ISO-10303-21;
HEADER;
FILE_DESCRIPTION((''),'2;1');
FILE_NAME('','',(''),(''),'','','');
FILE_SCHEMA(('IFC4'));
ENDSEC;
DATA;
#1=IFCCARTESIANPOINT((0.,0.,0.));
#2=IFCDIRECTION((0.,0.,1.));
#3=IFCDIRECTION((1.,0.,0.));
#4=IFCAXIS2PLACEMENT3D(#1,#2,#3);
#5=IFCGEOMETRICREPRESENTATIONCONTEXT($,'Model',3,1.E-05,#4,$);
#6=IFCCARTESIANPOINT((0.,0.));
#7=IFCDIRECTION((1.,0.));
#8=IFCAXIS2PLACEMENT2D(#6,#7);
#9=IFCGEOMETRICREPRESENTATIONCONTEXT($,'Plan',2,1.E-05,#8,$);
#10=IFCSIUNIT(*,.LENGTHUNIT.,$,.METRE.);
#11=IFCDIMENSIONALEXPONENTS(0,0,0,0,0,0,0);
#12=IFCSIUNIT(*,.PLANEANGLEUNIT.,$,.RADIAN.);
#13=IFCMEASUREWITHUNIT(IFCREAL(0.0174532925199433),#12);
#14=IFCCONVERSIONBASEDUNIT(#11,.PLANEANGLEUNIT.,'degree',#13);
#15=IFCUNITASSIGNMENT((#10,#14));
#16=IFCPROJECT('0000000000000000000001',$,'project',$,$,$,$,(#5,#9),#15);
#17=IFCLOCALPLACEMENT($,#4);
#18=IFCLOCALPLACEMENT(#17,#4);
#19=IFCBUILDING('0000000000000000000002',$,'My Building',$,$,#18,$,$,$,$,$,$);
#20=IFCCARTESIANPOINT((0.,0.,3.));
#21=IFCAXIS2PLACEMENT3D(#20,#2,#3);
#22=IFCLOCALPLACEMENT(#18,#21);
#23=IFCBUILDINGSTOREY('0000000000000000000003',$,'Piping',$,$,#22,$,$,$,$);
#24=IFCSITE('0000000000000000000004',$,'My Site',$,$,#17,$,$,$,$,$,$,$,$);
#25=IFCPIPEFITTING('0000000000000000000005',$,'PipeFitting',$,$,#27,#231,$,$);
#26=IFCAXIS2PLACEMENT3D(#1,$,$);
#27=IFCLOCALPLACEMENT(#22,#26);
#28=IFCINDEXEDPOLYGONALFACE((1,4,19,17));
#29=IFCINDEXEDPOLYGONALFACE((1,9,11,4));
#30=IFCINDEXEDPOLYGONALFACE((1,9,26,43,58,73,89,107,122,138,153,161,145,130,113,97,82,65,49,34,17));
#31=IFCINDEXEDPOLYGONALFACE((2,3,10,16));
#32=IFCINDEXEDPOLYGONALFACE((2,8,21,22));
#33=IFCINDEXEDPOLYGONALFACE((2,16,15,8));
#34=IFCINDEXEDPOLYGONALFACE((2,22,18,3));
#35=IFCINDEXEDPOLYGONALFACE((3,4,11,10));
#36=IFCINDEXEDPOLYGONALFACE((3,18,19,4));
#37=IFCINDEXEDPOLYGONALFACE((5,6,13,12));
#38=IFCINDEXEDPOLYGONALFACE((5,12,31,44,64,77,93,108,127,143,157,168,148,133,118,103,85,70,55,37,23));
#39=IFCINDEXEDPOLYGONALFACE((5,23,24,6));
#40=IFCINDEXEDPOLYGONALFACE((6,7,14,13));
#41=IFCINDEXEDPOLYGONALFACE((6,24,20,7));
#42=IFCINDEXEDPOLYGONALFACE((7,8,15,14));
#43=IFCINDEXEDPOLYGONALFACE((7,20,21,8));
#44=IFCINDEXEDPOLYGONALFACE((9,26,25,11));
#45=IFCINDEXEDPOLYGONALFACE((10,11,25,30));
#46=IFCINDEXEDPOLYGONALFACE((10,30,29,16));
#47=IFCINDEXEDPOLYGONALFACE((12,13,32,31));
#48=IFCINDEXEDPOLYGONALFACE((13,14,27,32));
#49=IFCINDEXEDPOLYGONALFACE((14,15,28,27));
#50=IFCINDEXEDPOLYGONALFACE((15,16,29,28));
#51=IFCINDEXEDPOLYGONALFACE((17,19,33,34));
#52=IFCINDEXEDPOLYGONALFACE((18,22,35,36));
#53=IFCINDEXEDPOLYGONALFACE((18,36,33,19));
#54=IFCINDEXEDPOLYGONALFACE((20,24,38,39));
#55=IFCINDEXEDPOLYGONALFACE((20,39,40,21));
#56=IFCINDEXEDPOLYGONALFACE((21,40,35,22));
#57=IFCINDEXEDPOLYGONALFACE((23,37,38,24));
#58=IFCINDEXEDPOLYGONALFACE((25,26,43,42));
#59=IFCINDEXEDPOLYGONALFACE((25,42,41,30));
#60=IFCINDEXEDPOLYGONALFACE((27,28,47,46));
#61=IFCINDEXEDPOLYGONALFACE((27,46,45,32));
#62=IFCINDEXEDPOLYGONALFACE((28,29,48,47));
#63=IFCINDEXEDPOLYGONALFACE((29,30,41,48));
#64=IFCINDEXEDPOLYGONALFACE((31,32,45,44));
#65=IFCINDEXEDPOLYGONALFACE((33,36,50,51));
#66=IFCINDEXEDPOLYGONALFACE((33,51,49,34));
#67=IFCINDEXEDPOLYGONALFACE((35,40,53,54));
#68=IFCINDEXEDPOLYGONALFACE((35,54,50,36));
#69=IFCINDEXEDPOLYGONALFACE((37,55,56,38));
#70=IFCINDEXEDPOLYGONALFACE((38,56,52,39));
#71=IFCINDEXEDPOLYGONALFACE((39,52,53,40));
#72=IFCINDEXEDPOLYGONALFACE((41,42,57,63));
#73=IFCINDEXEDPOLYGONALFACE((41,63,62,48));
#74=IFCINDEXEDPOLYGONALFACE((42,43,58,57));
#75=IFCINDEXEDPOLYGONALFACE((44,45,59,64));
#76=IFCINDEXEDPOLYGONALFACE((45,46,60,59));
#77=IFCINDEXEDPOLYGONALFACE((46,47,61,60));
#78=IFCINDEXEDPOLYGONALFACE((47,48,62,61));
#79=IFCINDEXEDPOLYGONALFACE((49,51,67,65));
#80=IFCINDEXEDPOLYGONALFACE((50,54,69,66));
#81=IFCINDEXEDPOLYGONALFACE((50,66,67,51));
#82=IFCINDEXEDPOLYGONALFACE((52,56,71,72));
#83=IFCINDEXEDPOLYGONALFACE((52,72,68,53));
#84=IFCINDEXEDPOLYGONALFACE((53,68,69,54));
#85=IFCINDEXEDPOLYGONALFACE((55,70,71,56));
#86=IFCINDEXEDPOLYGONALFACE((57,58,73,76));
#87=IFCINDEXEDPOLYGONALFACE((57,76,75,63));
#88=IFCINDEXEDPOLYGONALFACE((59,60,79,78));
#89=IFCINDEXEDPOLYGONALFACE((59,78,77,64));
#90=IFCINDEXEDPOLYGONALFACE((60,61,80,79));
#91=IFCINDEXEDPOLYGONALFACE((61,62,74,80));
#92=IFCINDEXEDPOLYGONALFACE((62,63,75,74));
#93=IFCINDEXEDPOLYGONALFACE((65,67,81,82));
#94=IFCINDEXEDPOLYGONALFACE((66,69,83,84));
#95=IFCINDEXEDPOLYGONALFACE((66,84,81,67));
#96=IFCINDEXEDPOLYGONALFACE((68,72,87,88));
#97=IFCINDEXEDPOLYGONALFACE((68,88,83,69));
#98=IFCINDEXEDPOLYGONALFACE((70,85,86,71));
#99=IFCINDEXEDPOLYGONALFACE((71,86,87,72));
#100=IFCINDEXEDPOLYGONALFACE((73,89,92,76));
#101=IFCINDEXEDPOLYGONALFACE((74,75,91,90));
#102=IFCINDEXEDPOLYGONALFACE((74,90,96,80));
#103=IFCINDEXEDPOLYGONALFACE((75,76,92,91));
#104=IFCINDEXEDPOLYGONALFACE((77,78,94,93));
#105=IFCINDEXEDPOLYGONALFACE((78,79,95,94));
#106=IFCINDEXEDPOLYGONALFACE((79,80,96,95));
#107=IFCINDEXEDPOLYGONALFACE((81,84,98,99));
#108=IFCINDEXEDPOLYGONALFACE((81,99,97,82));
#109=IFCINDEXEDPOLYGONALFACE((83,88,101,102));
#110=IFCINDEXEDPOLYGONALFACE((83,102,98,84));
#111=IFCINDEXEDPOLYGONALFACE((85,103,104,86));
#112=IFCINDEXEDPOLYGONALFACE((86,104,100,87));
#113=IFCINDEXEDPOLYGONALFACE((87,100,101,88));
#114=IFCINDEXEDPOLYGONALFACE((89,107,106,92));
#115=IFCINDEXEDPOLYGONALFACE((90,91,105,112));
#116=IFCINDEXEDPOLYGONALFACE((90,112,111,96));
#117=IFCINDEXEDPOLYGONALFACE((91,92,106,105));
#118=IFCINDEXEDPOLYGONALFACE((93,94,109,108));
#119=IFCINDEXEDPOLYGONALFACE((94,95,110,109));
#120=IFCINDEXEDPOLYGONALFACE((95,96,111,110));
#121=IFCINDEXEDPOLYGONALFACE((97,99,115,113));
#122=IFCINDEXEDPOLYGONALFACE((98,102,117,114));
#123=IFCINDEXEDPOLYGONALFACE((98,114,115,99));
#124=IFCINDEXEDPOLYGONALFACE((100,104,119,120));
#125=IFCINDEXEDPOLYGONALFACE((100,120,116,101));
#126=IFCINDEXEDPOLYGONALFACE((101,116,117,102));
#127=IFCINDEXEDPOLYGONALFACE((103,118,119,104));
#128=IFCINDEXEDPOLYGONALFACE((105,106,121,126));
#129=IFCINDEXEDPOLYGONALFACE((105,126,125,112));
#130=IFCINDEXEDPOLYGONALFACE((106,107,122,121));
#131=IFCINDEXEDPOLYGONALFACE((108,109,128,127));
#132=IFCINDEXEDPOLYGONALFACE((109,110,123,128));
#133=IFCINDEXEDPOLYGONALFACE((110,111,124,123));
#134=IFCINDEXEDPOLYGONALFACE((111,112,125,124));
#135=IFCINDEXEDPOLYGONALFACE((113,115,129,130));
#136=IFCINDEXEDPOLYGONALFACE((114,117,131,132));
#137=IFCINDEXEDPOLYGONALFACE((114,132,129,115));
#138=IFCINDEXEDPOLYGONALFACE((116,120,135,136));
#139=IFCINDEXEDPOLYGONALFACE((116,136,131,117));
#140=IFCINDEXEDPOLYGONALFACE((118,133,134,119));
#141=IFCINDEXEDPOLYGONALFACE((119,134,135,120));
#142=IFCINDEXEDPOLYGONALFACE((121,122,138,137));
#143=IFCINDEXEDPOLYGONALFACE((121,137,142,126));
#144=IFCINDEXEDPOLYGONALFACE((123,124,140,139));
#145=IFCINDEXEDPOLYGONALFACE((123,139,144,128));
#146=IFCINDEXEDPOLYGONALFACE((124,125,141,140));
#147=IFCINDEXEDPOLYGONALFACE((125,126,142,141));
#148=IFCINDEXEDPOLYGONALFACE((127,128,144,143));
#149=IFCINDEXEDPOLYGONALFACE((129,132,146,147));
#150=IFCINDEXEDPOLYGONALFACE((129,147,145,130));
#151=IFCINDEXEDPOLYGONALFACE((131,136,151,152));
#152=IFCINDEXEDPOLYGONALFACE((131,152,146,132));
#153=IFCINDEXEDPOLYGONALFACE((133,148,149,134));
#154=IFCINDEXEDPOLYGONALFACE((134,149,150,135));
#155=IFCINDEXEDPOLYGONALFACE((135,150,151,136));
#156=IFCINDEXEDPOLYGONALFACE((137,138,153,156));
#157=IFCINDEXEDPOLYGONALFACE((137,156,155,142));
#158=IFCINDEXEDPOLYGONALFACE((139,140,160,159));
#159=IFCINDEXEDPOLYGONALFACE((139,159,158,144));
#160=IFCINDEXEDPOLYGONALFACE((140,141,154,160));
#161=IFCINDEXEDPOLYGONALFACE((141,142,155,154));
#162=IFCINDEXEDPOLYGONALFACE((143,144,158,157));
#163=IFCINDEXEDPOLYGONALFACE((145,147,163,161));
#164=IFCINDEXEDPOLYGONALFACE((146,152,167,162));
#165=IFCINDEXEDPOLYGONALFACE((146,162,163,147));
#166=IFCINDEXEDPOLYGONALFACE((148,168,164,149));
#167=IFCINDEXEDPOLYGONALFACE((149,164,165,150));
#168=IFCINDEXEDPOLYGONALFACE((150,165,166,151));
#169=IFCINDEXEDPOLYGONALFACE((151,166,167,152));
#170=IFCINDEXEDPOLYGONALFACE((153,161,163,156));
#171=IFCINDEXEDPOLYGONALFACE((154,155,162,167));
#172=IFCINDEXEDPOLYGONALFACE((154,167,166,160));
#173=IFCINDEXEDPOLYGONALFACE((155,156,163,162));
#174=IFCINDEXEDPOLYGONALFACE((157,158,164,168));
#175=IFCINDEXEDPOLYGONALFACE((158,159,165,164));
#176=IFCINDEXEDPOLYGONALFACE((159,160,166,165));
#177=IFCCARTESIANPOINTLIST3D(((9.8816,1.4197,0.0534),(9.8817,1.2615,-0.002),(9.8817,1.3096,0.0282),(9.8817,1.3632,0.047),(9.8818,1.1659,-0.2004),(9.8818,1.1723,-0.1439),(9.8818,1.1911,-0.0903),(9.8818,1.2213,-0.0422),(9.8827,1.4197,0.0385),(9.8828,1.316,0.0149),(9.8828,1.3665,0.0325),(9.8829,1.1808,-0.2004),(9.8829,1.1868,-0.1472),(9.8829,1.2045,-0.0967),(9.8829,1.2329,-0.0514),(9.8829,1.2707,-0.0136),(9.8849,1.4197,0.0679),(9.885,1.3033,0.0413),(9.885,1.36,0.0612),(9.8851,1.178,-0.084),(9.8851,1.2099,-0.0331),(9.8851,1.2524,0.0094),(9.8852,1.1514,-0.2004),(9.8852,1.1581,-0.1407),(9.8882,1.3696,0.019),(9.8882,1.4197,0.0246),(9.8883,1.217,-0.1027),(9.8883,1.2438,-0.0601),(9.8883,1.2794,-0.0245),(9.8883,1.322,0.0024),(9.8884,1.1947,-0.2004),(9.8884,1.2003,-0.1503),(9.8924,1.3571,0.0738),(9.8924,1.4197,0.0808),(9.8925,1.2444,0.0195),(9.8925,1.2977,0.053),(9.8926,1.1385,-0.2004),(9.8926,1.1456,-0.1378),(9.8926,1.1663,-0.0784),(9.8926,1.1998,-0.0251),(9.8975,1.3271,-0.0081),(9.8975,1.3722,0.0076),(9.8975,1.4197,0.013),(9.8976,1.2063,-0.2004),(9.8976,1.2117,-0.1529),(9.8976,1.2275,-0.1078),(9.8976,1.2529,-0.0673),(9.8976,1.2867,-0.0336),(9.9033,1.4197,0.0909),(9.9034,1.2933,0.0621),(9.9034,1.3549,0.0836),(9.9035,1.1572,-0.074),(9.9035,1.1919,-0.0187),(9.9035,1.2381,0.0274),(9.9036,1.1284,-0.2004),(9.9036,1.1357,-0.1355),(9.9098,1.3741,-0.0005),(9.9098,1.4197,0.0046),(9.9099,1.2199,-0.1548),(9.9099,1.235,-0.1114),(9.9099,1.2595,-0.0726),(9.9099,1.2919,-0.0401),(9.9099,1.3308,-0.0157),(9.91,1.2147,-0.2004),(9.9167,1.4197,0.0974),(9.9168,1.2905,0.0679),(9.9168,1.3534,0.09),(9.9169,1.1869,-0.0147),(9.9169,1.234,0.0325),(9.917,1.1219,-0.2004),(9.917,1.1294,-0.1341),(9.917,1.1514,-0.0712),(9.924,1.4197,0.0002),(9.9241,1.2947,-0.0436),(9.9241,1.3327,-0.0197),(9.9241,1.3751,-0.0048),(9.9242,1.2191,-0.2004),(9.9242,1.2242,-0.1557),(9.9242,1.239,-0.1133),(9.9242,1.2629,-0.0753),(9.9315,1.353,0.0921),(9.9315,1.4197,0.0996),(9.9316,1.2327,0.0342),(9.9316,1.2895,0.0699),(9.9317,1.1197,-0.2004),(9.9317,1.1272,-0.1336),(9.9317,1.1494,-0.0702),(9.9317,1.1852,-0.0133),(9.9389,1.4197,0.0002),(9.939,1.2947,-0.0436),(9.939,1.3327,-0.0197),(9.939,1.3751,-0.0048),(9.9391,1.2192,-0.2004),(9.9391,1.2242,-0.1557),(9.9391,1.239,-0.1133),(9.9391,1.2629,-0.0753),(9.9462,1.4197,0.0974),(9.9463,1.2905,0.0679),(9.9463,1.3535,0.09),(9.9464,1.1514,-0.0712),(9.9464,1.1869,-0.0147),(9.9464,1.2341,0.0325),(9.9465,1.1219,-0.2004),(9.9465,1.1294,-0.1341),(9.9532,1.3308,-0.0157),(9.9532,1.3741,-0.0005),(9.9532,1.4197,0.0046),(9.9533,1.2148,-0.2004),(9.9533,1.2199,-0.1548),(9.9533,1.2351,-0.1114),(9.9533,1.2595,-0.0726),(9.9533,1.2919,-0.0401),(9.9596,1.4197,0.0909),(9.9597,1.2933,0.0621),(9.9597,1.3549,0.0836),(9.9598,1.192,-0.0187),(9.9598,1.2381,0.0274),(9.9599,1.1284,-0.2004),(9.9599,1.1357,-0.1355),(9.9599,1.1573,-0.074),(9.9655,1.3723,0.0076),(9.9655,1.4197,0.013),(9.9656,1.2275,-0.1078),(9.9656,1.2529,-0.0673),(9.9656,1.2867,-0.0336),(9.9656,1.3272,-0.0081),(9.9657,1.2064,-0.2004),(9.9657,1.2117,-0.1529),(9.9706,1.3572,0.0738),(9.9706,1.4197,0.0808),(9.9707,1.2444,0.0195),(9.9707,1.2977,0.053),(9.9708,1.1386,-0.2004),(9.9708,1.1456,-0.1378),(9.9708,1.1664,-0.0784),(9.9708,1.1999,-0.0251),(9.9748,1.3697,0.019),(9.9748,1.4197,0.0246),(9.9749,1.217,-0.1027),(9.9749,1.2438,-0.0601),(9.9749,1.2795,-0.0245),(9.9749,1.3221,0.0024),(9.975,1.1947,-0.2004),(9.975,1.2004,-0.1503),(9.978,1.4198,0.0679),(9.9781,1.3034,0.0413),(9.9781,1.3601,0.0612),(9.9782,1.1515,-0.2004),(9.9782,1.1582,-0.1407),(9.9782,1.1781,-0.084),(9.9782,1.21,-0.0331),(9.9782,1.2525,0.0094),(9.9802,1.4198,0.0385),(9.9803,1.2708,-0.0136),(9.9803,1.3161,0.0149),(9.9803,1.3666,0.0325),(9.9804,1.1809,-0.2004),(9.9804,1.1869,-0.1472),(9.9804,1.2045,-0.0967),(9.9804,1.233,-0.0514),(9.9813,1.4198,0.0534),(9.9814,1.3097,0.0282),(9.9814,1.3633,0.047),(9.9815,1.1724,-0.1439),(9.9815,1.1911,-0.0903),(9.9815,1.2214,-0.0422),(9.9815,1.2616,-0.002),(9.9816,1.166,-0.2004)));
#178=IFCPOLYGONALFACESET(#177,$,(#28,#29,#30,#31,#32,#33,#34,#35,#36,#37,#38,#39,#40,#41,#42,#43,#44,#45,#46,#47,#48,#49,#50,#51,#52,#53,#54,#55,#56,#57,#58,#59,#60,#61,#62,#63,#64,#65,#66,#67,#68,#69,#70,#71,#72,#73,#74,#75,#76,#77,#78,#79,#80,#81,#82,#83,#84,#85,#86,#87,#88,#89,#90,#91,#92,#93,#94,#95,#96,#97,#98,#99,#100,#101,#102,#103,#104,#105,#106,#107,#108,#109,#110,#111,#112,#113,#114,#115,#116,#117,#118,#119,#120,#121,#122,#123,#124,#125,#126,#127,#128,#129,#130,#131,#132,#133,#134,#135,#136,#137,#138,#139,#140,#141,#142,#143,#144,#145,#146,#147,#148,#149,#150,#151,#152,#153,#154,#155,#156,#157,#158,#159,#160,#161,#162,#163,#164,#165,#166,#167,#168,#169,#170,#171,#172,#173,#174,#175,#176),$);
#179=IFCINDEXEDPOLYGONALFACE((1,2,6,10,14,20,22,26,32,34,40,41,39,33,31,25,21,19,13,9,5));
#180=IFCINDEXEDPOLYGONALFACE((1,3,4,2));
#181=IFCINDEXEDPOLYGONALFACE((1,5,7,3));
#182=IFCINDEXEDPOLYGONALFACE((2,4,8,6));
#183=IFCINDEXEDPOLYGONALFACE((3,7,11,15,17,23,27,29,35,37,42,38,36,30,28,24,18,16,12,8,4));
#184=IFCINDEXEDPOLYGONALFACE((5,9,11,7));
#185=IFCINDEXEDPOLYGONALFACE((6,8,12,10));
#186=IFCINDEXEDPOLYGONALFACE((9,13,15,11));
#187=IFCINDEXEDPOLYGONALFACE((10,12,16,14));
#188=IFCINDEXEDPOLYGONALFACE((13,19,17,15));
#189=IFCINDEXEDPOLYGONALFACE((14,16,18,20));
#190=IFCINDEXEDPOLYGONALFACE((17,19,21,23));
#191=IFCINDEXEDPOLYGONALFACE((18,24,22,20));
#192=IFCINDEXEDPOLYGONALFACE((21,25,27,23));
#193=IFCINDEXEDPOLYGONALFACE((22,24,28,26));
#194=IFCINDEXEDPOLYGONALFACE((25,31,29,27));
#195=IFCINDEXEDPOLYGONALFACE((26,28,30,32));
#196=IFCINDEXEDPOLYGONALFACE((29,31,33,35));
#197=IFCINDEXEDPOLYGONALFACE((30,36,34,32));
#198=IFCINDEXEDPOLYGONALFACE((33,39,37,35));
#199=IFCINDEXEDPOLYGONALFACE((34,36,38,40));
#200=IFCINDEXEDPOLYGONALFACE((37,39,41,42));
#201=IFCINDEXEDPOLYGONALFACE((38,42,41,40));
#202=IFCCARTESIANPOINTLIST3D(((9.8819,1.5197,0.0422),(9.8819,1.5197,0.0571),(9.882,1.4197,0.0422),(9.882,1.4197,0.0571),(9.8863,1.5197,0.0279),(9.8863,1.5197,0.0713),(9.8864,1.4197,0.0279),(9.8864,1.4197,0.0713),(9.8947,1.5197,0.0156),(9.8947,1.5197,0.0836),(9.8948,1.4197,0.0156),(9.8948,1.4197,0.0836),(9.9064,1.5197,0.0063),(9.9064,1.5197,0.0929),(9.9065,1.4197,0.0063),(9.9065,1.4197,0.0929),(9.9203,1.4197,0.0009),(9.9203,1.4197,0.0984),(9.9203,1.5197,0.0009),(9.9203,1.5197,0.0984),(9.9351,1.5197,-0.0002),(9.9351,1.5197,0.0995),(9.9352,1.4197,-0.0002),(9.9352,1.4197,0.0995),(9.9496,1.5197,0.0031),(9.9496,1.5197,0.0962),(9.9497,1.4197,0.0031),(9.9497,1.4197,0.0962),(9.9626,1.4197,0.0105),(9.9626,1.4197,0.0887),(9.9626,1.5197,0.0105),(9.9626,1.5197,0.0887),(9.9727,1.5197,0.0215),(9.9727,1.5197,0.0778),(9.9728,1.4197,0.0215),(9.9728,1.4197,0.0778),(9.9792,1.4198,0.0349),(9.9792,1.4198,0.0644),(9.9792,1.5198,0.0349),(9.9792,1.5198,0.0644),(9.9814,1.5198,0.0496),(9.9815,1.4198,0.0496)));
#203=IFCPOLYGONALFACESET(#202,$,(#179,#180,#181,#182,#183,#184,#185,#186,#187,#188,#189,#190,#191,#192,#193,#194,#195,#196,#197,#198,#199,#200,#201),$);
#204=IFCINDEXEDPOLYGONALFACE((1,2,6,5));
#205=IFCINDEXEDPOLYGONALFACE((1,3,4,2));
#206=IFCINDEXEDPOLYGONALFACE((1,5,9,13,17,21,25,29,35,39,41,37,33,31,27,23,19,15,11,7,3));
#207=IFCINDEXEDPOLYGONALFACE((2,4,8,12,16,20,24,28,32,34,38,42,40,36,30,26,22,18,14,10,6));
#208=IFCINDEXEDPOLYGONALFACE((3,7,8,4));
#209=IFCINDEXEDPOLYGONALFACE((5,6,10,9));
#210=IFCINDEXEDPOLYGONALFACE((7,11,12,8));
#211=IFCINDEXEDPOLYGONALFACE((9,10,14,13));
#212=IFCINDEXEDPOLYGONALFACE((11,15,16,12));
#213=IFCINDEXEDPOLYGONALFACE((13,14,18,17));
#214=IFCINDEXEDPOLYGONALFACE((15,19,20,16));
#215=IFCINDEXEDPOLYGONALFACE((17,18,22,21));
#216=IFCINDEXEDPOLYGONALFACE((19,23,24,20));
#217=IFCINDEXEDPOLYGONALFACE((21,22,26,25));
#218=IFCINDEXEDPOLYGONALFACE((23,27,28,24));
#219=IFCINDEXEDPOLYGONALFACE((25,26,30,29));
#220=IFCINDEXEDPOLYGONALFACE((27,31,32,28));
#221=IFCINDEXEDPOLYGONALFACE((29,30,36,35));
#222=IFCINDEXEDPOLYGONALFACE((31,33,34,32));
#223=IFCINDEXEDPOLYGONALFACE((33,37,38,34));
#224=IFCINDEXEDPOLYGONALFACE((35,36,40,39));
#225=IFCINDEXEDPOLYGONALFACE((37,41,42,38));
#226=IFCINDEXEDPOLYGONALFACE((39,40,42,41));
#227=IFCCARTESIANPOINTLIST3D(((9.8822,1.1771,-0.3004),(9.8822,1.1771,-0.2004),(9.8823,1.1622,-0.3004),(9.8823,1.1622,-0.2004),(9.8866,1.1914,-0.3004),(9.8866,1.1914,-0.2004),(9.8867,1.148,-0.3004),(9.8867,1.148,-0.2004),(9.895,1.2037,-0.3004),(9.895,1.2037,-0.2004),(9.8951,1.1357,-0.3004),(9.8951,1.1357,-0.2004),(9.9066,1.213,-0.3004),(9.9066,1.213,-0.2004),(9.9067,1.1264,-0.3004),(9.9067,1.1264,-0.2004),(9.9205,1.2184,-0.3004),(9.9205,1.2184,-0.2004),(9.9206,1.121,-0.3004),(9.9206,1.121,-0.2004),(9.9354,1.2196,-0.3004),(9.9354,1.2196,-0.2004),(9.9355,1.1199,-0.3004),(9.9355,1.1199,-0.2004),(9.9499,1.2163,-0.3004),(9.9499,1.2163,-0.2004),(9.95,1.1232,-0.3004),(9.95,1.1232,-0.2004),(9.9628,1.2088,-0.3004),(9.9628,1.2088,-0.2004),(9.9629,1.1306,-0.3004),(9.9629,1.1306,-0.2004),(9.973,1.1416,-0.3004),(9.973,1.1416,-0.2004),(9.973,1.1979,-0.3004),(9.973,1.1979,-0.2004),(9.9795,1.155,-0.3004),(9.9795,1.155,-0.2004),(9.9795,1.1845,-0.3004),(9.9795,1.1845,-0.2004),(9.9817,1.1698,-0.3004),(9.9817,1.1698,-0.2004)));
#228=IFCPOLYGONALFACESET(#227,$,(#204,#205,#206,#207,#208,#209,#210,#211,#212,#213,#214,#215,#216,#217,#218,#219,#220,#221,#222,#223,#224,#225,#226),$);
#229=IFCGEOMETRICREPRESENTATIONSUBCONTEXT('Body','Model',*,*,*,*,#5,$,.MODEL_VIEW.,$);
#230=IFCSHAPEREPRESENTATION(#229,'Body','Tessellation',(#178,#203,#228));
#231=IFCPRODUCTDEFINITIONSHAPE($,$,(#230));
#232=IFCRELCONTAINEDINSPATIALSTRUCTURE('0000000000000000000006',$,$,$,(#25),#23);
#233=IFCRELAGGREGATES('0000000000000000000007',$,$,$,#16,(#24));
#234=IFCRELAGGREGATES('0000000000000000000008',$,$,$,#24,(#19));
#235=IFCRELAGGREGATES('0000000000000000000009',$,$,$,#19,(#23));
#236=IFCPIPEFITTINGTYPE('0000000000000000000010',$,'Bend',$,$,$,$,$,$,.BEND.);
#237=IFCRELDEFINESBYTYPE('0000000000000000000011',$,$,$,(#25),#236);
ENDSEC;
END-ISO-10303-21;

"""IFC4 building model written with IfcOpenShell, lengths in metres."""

from ifc_helpers import new_model, entity, si_unit, converted_unit, frame, origin_with_axes, origin_2d_with_axis, place, context, subcontext, project, spatial, circle, extrude, source, transform, mapped, type_object, type_shapes, element, save


model = new_model("IFC4")

# Units and contexts
model_context = context("Model", 3, precision=1e-05, world=origin_with_axes())
plan_context = context("Plan", 2, precision=1e-05, world=origin_2d_with_axis())
body_context = subcontext(model_context, "Body", "Model", "MODEL_VIEW")
ifc_project = project(units=[si_unit("LENGTHUNIT", "METRE"), converted_unit("PLANEANGLEUNIT", "degree", entity("IfcReal", 0.0174532925199433), si_unit("PLANEANGLEUNIT", "RADIAN"), dimensions=[0, 0, 0, 0, 0, 0, 0])], contexts=[model_context, plan_context])

# Site, building, storey
site_placement = place(None, origin_with_axes())
site = spatial("IfcSite", under=ifc_project, at=site_placement, Name="My Site")
building_placement = place(site_placement, origin_with_axes())
building = spatial("IfcBuilding", under=site, at=building_placement, Name="My Building")
storey_placement = place(building_placement, frame((0.0, 0.0, 3.0), z_axis=(0.0, 0.0, 1.0), x_axis=(1.0, 0.0, 0.0)))
storey = spatial("IfcBuildingStorey", under=building, at=storey_placement, Name="Piping")

# Pipe fitting
pipe_fitting_type_1 = type_object("IfcPipeFittingType", Name="Bend", PredefinedType="BEND")
shared_shape = source(origin_with_axes(), body_context, "Body", "SolidModel", [
    entity("IfcSweptDiskSolid", entity("IfcIndexedPolyCurve", entity("IfcCartesianPointList3D", [[0.0, 0.0, 0.1], [0.0, -0.0732, 0.2768], [0.0, -0.25, 0.35]]), [entity("IfcArcIndex", [1, 2, 3])]), 0.05),
    extrude(circle(Radius=0.05), origin_with_axes(), (0.0, 0.0, 1.0), 0.1),
    extrude(circle(Radius=0.05), frame((0.0, -0.25, 0.35), z_axis=(0.0, -1.0, -0.000001), x_axis=(1.0, 0.0, 0.0)), (0.0, 0.0, 1.0), 0.1),
])
type_shapes(pipe_fitting_type_1, [shared_shape])
for number, where, z_axis, x_axis, name in (
    (1, (9.9314, 1.5197, 0.0496), (0.000872, -1.0, 0.000001), (1.0, 0.000872, 0.0), "PipeFitting"),
):
    element("IfcPipeFitting", number, at=place(storey_placement, frame(where, z_axis=z_axis, x_axis=x_axis)), inside=storey, type_object=pipe_fitting_type_1, Name=name, context=body_context, shape_type="MappedRepresentation", body=[
        mapped(shared_shape, transform((0.0, 0.0, 0.0), x_axis=(1.0, 0.0, 0.0), y_axis=(0.0, 1.0, 0.0), z_axis=(0.0, 0.0, 1.0), scale=1.0)),
    ])

save(model, "model.ifc")
